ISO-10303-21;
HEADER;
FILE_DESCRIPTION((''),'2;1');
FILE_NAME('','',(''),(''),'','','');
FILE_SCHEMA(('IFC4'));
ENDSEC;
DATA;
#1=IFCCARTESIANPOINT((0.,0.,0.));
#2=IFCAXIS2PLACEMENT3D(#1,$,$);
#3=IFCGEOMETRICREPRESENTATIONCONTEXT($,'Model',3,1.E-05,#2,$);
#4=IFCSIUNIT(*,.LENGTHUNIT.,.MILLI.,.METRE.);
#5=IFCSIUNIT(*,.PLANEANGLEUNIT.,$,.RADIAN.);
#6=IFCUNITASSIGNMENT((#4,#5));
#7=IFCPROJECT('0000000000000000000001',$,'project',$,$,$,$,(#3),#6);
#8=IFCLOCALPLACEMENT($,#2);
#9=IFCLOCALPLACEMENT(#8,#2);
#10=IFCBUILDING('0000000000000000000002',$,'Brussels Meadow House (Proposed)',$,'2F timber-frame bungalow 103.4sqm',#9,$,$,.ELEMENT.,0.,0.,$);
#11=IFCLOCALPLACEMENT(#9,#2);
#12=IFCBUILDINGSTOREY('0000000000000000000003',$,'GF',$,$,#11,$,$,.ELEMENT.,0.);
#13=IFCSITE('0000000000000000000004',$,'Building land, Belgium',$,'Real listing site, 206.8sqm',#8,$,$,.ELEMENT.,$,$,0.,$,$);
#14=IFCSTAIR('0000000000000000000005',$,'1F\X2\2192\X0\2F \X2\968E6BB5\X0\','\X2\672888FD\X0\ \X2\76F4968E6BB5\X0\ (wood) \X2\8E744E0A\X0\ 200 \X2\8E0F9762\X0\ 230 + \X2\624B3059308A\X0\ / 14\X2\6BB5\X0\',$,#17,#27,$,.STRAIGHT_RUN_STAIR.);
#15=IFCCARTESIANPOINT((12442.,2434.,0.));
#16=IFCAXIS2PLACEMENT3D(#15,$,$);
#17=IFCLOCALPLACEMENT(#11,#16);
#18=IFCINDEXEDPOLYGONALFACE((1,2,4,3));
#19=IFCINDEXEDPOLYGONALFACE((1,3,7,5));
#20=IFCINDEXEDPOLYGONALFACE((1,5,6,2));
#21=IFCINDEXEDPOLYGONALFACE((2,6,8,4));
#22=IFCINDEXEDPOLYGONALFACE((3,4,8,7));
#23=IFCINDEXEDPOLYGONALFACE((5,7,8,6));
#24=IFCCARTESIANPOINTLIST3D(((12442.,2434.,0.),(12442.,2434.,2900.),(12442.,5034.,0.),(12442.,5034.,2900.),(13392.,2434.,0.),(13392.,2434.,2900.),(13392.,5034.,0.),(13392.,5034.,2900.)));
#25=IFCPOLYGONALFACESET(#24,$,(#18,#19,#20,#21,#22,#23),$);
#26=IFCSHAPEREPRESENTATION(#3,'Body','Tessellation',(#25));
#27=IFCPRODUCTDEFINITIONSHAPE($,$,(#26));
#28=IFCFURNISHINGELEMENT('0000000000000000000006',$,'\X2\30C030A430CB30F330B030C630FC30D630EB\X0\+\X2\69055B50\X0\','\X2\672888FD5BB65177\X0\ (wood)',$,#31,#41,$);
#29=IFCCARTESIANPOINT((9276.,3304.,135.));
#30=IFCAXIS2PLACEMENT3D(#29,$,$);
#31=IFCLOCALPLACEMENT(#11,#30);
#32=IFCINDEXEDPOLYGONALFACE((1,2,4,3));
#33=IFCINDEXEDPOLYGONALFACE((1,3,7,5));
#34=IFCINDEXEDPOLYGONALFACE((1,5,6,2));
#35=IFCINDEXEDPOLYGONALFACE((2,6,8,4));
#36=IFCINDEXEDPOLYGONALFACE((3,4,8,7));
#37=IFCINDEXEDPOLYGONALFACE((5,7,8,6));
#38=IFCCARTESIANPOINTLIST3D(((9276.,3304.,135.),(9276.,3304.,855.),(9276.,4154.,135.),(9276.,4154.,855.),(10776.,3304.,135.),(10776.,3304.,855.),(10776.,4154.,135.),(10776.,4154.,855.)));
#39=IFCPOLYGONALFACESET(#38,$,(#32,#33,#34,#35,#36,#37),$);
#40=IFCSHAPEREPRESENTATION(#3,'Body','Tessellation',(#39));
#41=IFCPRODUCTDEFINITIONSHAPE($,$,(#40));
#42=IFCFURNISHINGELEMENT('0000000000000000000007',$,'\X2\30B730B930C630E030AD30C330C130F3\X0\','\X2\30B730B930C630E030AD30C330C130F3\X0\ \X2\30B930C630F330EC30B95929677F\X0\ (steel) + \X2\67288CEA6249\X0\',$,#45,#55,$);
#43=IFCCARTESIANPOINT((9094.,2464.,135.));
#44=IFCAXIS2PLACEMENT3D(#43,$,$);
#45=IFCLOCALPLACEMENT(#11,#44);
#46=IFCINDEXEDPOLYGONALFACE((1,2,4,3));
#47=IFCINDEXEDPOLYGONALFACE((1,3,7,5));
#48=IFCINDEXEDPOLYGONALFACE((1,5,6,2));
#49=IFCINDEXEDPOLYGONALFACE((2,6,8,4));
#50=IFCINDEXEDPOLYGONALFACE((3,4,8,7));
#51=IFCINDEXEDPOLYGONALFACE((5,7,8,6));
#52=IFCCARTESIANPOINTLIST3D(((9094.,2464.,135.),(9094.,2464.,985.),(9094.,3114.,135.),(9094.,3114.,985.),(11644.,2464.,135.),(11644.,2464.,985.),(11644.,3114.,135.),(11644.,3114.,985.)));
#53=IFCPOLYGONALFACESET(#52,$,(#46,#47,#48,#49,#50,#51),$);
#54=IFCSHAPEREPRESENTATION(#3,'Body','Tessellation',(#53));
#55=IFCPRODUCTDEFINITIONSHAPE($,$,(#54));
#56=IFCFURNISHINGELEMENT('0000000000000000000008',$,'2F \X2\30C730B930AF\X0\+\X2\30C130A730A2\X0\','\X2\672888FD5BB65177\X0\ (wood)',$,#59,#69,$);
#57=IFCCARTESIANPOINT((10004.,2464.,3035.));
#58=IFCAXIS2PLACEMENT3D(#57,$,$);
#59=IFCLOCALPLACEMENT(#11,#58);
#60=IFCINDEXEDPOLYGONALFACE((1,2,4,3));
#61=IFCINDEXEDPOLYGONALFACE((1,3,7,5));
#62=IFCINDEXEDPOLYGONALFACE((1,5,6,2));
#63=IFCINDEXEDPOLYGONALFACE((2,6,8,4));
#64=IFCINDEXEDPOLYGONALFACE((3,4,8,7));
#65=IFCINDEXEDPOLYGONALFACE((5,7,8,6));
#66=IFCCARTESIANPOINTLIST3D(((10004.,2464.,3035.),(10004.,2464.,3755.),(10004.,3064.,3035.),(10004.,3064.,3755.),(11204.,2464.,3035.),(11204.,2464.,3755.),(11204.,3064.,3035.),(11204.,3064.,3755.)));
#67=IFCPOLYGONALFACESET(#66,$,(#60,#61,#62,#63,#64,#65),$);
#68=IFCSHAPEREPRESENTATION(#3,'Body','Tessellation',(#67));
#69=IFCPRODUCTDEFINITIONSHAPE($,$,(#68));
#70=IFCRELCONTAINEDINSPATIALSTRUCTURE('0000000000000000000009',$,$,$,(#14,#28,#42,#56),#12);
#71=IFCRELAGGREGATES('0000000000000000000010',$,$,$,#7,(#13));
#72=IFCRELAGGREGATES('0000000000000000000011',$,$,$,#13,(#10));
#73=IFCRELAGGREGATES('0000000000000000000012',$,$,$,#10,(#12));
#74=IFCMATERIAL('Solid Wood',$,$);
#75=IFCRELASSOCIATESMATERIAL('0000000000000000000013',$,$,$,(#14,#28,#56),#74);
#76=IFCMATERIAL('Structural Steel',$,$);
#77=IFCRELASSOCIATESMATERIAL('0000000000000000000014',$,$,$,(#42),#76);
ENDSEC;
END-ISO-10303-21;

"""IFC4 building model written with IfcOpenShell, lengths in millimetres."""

from ifc_helpers import new_model, si_unit, frame, frame_2d, origin, place, context, project, spatial, rectangle, extrude, material, element, save


model = new_model("IFC4")

# Units and contexts
model_context = context("Model", 3, precision=1e-05, world=origin())
ifc_project = project(units=[si_unit("LENGTHUNIT", "METRE", prefix="MILLI"), si_unit("PLANEANGLEUNIT", "RADIAN")], contexts=[model_context])

# Site, building, storey
site_placement = place(None, origin())
site = spatial("IfcSite", under=ifc_project, at=site_placement, Name="Building land, Belgium", ObjectType="Real listing site, 206.8sqm", CompositionType="ELEMENT", RefElevation=0.0)
building_placement = place(site_placement, origin())
building = spatial("IfcBuilding", under=site, at=building_placement, Name="Brussels Meadow House (Proposed)", ObjectType="2F timber-frame bungalow 103.4sqm", CompositionType="ELEMENT", ElevationOfRefHeight=0.0, ElevationOfTerrain=0.0)
storey_placement = place(building_placement, origin())
storey = spatial("IfcBuildingStorey", under=building, at=storey_placement, Name="GF", CompositionType="ELEMENT", Elevation=0.0)

# Shared definitions
ifc_material_1 = material(Name="Solid Wood")

# Stair
stair_placement = place(storey_placement, frame((12442.0, 2434.0, 0.0)))
element("IfcStair", 1, at=stair_placement, inside=storey, material=ifc_material_1, Name="1F→2F 階段", Description="木製 直階段 (wood) 蹴上 200 踏面 230 + 手すり / 14段", PredefinedType="STRAIGHT_RUN_STAIR", context=model_context, shape_type="SweptSolid", body=[
    extrude(rectangle(XDim=950.0, YDim=2600.0, at=frame_2d((475.0, 1300.0))), frame((12442.0, 2434.0, 0.0)), (0.0, 0.0, 1.0), 2900.0),
])

# Furnishing elements
furnishing_1_placement = place(storey_placement, frame((9276.0, 3304.0, 135.0)))
element("IfcFurnishingElement", 2, at=furnishing_1_placement, inside=storey, material=ifc_material_1, Name="ダイニングテーブル+椅子", Description="木製家具 (wood)", context=model_context, shape_type="SweptSolid", body=[
    extrude(rectangle(XDim=1500.0, YDim=850.0, at=frame_2d((750.0, 425.0))), frame((9276.0, 3304.0, 135.0)), (0.0, 0.0, 1.0), 720.0),
])
ifc_material_2 = material(Name="Structural Steel")
furnishing_2_placement = place(storey_placement, frame((9094.0, 2464.0, 135.0)))
element("IfcFurnishingElement", 3, at=furnishing_2_placement, inside=storey, material=ifc_material_2, Name="システムキッチン", Description="システムキッチン ステンレス天板 (steel) + 木質扉", context=model_context, shape_type="SweptSolid", body=[
    extrude(rectangle(XDim=2550.0, YDim=650.0, at=frame_2d((1275.0, 325.0))), frame((9094.0, 2464.0, 135.0)), (0.0, 0.0, 1.0), 850.0),
])
furnishing_3_placement = place(storey_placement, frame((10004.0, 2464.0, 3035.0)))
element("IfcFurnishingElement", 4, at=furnishing_3_placement, inside=storey, material=ifc_material_1, Name="2F デスク+チェア", Description="木製家具 (wood)", context=model_context, shape_type="SweptSolid", body=[
    extrude(rectangle(XDim=1200.0, YDim=600.0, at=frame_2d((600.0, 300.0))), frame((10004.0, 2464.0, 3035.0)), (0.0, 0.0, 1.0), 720.0),
])

save(model, "model.ifc")
